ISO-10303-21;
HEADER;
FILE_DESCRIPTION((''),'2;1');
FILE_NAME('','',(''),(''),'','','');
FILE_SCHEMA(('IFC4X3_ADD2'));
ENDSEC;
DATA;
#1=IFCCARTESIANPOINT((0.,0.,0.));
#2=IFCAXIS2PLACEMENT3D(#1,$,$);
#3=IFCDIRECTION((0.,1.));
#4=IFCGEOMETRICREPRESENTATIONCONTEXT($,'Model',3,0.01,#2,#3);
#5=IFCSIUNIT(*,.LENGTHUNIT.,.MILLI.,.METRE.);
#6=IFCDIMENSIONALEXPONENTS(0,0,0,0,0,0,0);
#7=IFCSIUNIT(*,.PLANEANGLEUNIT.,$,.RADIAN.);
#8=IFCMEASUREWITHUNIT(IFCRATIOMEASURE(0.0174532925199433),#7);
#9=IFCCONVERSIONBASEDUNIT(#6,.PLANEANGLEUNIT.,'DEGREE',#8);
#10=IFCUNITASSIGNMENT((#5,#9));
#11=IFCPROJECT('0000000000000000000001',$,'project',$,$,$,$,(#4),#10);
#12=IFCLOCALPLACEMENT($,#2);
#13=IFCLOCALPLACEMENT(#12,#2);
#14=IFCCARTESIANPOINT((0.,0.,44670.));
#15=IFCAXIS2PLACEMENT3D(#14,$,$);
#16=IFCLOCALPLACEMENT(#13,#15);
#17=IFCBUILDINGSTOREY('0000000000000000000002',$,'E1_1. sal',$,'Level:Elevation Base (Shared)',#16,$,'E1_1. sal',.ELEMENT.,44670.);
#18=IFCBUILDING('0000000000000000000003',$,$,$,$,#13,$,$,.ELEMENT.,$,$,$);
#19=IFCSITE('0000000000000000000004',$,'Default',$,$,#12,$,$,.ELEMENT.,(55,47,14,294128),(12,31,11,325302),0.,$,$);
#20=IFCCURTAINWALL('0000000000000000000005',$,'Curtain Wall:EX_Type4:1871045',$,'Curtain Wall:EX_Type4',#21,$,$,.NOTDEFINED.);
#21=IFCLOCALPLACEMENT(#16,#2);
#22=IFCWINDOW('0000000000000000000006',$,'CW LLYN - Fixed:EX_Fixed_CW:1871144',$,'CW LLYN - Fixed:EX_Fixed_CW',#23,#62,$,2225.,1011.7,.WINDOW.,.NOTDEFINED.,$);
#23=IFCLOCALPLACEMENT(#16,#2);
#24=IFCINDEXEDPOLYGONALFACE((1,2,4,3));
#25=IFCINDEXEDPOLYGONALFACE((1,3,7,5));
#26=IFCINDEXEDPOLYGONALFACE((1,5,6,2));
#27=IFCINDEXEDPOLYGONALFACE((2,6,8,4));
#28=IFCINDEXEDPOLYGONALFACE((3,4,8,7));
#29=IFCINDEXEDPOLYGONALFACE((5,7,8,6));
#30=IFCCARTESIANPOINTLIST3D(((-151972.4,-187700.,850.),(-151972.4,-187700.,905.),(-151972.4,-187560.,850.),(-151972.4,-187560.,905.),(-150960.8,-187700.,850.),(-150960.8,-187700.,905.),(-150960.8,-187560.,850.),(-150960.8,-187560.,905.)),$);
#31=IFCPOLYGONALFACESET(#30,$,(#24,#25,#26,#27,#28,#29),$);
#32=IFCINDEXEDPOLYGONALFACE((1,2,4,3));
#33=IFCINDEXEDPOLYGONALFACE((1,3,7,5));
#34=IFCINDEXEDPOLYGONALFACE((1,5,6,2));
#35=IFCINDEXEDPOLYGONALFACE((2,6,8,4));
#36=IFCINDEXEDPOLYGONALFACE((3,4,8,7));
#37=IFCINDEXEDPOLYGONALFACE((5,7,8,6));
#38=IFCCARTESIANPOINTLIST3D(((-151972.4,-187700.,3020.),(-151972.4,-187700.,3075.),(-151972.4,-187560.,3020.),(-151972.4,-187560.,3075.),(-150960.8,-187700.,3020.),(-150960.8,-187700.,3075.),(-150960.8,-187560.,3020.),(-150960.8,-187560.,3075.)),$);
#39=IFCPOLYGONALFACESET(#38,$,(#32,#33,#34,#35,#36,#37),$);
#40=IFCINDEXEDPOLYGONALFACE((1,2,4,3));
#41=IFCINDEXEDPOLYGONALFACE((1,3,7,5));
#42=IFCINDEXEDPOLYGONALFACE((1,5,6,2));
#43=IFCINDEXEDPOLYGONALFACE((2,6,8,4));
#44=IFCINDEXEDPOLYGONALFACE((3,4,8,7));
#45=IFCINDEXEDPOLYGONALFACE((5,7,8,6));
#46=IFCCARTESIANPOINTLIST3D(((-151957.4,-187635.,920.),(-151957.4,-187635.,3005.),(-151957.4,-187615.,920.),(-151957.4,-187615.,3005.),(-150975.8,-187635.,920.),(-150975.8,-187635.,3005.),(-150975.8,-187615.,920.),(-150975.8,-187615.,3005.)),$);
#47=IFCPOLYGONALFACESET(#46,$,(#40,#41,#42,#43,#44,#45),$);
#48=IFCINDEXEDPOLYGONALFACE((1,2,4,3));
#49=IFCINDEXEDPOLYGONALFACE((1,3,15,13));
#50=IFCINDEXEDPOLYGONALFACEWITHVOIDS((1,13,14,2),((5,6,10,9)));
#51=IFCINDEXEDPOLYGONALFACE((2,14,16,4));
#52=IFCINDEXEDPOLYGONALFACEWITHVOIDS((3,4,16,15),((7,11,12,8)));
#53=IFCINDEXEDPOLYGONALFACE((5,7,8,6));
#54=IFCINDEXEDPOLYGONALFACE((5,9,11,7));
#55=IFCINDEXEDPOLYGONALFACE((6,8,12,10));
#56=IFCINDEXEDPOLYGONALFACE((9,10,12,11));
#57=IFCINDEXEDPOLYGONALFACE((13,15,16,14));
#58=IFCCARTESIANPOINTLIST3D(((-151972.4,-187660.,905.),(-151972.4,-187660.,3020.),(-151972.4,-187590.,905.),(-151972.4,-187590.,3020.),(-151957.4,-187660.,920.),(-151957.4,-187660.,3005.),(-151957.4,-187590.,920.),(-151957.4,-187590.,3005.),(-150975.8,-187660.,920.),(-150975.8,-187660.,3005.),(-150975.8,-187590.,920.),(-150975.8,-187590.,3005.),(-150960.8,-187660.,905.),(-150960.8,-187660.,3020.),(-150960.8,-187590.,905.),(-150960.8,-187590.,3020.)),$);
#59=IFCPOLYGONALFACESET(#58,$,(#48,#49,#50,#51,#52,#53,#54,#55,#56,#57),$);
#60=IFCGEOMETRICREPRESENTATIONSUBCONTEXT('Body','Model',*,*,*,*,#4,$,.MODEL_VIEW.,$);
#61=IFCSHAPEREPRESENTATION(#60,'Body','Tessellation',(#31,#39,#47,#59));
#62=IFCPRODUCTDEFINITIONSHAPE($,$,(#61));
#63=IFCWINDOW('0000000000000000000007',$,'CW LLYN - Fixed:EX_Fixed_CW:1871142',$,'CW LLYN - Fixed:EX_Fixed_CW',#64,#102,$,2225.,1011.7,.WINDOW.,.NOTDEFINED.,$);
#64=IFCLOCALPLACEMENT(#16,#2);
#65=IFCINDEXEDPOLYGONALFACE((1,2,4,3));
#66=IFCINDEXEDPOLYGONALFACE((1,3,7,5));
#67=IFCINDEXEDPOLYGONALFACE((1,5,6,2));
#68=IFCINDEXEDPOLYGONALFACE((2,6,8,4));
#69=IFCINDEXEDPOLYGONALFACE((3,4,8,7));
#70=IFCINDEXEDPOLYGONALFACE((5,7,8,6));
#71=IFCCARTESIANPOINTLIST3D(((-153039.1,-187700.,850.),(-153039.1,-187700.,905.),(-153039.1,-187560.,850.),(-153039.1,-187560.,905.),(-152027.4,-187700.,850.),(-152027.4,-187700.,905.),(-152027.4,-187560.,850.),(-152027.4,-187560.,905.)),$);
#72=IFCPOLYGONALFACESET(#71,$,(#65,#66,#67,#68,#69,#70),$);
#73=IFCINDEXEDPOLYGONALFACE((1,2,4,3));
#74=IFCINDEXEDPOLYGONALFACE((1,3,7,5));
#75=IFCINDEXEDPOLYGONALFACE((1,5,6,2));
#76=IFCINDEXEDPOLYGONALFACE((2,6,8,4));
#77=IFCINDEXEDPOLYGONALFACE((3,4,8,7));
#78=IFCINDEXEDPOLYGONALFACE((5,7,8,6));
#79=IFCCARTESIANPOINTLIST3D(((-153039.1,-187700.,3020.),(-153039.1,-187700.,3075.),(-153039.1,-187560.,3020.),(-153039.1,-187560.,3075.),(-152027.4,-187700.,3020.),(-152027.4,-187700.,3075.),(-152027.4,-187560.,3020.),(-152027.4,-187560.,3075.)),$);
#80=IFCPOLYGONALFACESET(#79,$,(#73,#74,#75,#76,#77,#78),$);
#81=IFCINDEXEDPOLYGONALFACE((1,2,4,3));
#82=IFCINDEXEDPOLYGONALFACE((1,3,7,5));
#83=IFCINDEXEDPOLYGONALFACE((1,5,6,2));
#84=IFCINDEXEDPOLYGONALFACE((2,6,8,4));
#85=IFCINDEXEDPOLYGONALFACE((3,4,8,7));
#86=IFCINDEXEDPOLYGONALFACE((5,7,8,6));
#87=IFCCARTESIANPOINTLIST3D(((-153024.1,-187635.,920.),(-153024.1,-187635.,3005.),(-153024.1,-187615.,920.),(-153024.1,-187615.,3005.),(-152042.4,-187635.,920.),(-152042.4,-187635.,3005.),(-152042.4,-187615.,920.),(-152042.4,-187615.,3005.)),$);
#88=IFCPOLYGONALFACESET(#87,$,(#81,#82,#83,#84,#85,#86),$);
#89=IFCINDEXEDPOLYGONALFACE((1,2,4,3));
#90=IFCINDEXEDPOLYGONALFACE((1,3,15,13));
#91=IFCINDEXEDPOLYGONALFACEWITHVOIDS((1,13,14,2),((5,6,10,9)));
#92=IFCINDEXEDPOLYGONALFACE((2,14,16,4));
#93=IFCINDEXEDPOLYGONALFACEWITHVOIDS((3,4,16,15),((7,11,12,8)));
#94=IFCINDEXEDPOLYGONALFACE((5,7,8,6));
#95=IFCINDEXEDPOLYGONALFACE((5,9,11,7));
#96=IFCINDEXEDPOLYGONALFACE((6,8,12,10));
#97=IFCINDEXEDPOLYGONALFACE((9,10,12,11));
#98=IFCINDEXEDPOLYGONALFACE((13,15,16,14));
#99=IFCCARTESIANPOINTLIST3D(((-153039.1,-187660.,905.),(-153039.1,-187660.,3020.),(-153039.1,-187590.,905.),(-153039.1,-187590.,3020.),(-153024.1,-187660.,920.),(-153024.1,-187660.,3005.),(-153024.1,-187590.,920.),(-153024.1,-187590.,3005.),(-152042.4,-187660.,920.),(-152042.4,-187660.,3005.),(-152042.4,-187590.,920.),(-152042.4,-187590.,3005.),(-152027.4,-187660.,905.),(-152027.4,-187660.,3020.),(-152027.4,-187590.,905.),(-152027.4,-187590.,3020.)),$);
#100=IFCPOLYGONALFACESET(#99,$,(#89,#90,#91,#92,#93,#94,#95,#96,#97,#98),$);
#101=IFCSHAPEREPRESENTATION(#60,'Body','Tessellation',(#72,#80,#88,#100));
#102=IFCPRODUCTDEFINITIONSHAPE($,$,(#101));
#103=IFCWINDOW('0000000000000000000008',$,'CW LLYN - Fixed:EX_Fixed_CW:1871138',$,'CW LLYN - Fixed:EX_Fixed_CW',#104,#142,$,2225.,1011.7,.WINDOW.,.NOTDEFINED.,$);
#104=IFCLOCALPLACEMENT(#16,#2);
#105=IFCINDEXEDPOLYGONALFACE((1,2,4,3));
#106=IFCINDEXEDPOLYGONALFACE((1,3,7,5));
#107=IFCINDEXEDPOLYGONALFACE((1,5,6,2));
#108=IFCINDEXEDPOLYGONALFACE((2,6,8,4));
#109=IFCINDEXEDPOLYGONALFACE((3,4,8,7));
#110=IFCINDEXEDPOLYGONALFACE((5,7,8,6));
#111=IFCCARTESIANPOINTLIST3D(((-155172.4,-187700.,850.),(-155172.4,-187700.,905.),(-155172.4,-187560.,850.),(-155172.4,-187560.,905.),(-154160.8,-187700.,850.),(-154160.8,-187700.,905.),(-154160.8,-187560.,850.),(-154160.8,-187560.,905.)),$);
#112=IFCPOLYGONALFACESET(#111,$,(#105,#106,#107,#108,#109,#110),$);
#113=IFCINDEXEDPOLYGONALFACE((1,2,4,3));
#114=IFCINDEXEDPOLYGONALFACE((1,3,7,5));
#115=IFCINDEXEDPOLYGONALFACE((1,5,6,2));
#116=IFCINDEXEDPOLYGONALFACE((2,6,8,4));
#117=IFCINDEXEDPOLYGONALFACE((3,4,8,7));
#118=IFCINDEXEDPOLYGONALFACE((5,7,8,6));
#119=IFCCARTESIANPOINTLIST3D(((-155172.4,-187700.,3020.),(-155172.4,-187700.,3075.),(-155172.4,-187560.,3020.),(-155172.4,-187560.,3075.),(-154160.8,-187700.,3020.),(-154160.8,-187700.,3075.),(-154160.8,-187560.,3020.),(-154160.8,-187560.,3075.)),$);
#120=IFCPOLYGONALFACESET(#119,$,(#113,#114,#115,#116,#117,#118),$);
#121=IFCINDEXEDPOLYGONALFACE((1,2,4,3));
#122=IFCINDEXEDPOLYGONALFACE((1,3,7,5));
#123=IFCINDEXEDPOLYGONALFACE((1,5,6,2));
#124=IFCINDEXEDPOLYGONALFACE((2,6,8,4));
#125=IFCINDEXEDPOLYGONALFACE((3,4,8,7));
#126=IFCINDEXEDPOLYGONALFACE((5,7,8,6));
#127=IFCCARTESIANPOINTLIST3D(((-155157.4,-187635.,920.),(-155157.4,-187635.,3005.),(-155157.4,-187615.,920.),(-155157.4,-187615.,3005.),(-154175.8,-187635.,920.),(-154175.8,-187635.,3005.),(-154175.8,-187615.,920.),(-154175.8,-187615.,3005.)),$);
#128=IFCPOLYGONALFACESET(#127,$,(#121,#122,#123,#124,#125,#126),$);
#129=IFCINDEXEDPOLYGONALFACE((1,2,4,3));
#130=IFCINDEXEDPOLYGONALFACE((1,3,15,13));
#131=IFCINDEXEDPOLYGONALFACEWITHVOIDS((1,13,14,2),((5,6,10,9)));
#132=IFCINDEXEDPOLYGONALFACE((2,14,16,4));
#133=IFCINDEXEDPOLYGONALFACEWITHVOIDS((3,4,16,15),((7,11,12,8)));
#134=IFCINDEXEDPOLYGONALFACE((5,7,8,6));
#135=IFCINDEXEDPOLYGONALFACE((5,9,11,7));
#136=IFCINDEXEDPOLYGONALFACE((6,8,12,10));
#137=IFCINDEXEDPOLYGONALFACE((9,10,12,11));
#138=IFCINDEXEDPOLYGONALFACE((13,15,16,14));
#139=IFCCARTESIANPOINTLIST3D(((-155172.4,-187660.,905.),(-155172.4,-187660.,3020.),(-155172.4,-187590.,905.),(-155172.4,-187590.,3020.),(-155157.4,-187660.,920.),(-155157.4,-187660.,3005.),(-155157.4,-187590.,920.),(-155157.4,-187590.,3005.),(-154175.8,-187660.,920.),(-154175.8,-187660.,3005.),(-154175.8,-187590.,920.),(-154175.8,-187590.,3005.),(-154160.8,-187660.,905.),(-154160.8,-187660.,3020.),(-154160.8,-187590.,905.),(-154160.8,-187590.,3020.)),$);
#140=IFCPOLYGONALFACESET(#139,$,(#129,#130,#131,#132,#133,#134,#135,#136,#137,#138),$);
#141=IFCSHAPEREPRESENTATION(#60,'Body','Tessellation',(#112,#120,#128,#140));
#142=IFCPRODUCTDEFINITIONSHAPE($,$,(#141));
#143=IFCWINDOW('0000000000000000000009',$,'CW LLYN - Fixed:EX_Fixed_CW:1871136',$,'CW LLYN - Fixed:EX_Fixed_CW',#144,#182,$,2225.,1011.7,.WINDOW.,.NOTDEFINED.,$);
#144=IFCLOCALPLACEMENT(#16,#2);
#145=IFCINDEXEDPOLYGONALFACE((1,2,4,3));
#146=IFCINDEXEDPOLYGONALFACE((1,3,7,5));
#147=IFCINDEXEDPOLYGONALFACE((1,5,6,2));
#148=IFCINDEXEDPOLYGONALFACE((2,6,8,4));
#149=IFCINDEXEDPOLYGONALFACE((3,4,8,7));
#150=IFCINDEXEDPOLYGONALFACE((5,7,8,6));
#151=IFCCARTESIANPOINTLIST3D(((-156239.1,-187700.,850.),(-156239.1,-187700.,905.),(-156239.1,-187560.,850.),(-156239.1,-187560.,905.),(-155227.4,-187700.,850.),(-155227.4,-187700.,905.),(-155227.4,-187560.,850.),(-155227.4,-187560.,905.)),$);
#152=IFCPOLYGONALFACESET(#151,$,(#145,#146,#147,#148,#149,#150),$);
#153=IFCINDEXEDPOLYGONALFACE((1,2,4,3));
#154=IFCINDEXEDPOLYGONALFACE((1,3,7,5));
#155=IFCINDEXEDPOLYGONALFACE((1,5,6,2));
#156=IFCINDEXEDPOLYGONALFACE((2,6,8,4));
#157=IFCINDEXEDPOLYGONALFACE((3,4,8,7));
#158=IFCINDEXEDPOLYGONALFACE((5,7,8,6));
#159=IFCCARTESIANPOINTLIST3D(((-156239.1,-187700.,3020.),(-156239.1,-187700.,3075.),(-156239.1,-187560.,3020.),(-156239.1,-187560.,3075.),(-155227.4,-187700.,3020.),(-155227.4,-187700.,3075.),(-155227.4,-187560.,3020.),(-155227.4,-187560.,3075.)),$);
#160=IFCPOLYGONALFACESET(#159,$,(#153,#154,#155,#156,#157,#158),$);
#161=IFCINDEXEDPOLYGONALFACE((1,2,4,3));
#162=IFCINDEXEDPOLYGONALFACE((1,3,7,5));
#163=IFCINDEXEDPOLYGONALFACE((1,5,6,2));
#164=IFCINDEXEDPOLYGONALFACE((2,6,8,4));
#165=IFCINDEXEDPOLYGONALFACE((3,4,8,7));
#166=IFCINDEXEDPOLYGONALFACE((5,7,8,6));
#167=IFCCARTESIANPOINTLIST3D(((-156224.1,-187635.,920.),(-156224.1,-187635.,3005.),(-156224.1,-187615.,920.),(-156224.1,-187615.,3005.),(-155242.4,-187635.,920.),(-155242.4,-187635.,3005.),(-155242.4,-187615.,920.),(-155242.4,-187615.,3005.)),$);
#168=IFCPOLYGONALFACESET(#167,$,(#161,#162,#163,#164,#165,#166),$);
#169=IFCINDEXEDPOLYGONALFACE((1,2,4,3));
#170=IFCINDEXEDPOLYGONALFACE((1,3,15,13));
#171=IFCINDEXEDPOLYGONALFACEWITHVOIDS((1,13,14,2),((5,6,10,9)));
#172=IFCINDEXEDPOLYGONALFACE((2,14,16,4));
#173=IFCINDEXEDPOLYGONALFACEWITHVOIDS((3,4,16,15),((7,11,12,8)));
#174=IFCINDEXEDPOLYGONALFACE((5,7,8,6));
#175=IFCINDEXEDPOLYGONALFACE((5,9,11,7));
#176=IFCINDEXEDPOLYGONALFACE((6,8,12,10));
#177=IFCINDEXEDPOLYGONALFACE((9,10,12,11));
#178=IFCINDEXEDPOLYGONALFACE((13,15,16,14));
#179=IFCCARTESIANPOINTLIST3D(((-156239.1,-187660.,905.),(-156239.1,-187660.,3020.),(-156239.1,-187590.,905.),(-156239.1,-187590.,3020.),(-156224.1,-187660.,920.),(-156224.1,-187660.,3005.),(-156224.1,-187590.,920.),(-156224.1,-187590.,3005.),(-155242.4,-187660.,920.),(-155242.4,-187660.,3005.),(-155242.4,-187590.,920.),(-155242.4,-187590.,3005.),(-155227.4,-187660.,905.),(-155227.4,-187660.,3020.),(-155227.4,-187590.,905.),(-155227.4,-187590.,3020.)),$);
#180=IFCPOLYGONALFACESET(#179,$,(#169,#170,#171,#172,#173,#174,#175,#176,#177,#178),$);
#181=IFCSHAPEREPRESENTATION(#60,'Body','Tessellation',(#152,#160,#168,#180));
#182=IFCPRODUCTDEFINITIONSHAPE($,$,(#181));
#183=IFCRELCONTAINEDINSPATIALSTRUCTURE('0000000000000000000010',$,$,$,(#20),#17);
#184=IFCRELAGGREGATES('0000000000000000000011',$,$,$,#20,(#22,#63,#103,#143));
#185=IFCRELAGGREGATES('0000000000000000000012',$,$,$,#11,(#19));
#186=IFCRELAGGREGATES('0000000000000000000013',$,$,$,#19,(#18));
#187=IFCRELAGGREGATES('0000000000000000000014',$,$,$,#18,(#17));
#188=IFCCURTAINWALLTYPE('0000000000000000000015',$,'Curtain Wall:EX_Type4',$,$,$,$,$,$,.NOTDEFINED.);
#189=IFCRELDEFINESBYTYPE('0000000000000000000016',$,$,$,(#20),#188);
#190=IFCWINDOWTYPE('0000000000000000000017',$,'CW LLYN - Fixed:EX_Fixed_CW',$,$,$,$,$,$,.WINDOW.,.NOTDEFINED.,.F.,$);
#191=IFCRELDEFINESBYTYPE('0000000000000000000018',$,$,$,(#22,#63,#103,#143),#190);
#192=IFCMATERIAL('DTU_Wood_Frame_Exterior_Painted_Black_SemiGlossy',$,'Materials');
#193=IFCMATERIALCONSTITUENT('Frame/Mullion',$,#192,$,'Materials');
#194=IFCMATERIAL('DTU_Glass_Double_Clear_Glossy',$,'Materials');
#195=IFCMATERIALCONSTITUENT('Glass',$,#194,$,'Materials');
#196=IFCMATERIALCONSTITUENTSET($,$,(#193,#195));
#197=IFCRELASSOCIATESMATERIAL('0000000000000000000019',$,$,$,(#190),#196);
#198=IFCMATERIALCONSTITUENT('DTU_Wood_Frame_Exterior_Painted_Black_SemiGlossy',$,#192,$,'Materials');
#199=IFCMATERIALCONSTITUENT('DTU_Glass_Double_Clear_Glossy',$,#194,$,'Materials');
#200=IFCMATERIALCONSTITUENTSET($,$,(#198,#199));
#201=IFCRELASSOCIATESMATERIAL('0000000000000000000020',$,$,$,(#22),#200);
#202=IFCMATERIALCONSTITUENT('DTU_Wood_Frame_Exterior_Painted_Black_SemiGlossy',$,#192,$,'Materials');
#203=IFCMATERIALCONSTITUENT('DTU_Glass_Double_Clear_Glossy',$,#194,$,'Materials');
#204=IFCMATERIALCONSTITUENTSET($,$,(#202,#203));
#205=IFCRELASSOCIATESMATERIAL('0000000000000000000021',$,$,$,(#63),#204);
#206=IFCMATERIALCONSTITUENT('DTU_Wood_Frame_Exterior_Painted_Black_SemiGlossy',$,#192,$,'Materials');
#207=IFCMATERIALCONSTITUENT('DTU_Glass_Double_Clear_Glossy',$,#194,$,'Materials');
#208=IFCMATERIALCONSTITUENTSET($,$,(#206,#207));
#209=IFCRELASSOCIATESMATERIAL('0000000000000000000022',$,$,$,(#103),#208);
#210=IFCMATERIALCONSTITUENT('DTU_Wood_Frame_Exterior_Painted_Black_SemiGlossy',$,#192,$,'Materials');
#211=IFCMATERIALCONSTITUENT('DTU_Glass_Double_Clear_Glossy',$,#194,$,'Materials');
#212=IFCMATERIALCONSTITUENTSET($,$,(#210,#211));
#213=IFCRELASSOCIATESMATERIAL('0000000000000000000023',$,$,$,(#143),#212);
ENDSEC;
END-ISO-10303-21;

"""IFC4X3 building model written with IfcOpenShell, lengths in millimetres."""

from ifc_helpers import new_model, entity, si_unit, converted_unit, direction, frame, frame_2d, origin, origin_2d_with_axis, place, context, subcontext, project, spatial, polyline, rectangle, outline, extrude, source, transform, mapped, material, constituent, constituent_set, type_object, type_shapes, element, aggregate, save


model = new_model("IFC4X3")

# Units and contexts
model_context = context("Model", 3, precision=0.01, world=origin(), true_north=direction((0.0, 1.0)))
body_context = subcontext(model_context, "Body", "Model", "MODEL_VIEW")
ifc_project = project(units=[si_unit("LENGTHUNIT", "METRE", prefix="MILLI"), converted_unit("PLANEANGLEUNIT", "DEGREE", entity("IfcRatioMeasure", 0.0174532925199433), si_unit("PLANEANGLEUNIT", "RADIAN"), dimensions=[0, 0, 0, 0, 0, 0, 0])], contexts=[model_context])

# Site, building, storey
site_placement = place(None, origin())
site = spatial("IfcSite", under=ifc_project, at=site_placement, Name="Default", CompositionType="ELEMENT", RefLatitude=(55, 47, 14, 294128), RefLongitude=(12, 31, 11, 325302), RefElevation=0.0)
building_placement = place(site_placement, origin())
building = spatial("IfcBuilding", under=site, at=building_placement, CompositionType="ELEMENT")
storey_placement = place(building_placement, frame((0.0, 0.0, 44670.0)))
storey = spatial("IfcBuildingStorey", under=building, at=storey_placement, Name="E1_1. sal", ObjectType="Level:Elevation Base (Shared)", LongName="E1_1. sal", CompositionType="ELEMENT", Elevation=44670.0)

# Curtain wall, windows
curtain_wall_type = type_object("IfcCurtainWallType", Name="Curtain Wall:EX_Type4", PredefinedType="NOTDEFINED")
curtain_wall_placement = place(storey_placement, frame((0.0, 0.0, -44670.0)))
curtain_wall = element("IfcCurtainWall", 1, at=curtain_wall_placement, inside=storey, type_object=curtain_wall_type, Name="Curtain Wall:EX_Type4:1871045", ObjectType="Curtain Wall:EX_Type4", PredefinedType="NOTDEFINED")
ifc_material_1 = material(Name="DTU_Wood_Frame_Exterior_Painted_Black_SemiGlossy", Category="Materials")
ifc_material_2 = material(Name="DTU_Glass_Double_Clear_Glossy", Category="Materials")
ifc_constituent_1 = constituent(ifc_material_1, Name="Frame/Mullion", Category="Materials")
ifc_constituent_2 = constituent(ifc_material_2, Name="Glass", Category="Materials")
ifc_constituent_set_1 = constituent_set(constituents=[ifc_constituent_1, ifc_constituent_2])
window_type_1 = type_object("IfcWindowType", Name="CW LLYN - Fixed:EX_Fixed_CW", ParameterTakesPrecedence=False, PartitioningType="NOTDEFINED", PredefinedType="WINDOW", material=ifc_constituent_set_1)
shared_shape_1 = source(origin(), body_context, "Body", "SweptSolid", [
    extrude(rectangle(XDim=140.0, YDim=1011.7, at=origin_2d_with_axis()), frame((0.0, -130.0, 0.0), z_axis=(0.0, 0.0, 1.0), x_axis=(0.0, -1.0, 0.0)), (0.0, 0.0, 1.0), 55.0),
    extrude(rectangle(XDim=140.0, YDim=1011.7, at=frame_2d((0.0, 0.0), x_axis=(1.0, 0.0))), frame((0.0, -130.0, 2170.0), z_axis=(0.0, 0.0, 1.0), x_axis=(0.0, -1.0, 0.0)), (0.0, 0.0, 1.0), 55.0),
    extrude(rectangle(XDim=981.7, YDim=20.0, at=frame_2d((0.0, 0.0), x_axis=(1.0, 0.0))), frame((0.0, -125.0, 70.0), z_axis=(0.0, 0.0, 1.0), x_axis=(-1.0, 0.0, 0.0)), (0.0, 0.0, 1.0), 2085.0),
    extrude(outline(polyline([(-1057.5, -505.8), (1057.5, -505.8), (1057.5, 505.8), (-1057.5, 505.8), (-1057.5, -505.8)]), holes=[polyline([(-1042.5, 490.8), (1042.5, 490.8), (1042.5, -490.8), (-1042.5, -490.8), (-1042.5, 490.8)])]), frame((0.0, -90.0, 1112.5), z_axis=(0.0, -1.0, 0.0), x_axis=(0.0, 0.0, 1.0)), (0.0, 0.0, 1.0), 70.0),
])
type_shapes(window_type_1, [shared_shape_1])
ifc_constituent_3 = constituent(ifc_material_1, Name="DTU_Wood_Frame_Exterior_Painted_Black_SemiGlossy", Category="Materials")
ifc_constituent_4 = constituent(ifc_material_2, Name="DTU_Glass_Double_Clear_Glossy", Category="Materials")
ifc_constituent_set_2 = constituent_set(constituents=[ifc_constituent_3, ifc_constituent_4])
window_1_placement = place(curtain_wall_placement, frame((-151466.6, -187500.0, 45520.0)))
window_1 = element("IfcWindow", 2, at=window_1_placement, type_object=window_type_1, material=ifc_constituent_set_2, Name="CW LLYN - Fixed:EX_Fixed_CW:1871144", ObjectType="CW LLYN - Fixed:EX_Fixed_CW", OverallHeight=2225.0, OverallWidth=1011.7, PartitioningType="NOTDEFINED", PredefinedType="WINDOW", context=body_context, shape_type="MappedRepresentation", body=[
    mapped(shared_shape_1, transform((0.0, 0.0, 0.0), scale=1.0)),
])
ifc_constituent_5 = constituent(ifc_material_1, Name="DTU_Wood_Frame_Exterior_Painted_Black_SemiGlossy", Category="Materials")
ifc_constituent_6 = constituent(ifc_material_2, Name="DTU_Glass_Double_Clear_Glossy", Category="Materials")
ifc_constituent_set_3 = constituent_set(constituents=[ifc_constituent_5, ifc_constituent_6])
window_2_placement = place(curtain_wall_placement, frame((-152533.3, -187500.0, 45520.0)))
window_2 = element("IfcWindow", 3, at=window_2_placement, type_object=window_type_1, material=ifc_constituent_set_3, Name="CW LLYN - Fixed:EX_Fixed_CW:1871142", ObjectType="CW LLYN - Fixed:EX_Fixed_CW", OverallHeight=2225.0, OverallWidth=1011.7, PartitioningType="NOTDEFINED", PredefinedType="WINDOW", context=body_context, shape_type="MappedRepresentation", body=[
    mapped(shared_shape_1, transform((0.0, 0.0, 0.0), scale=1.0)),
])
ifc_constituent_7 = constituent(ifc_material_1, Name="DTU_Wood_Frame_Exterior_Painted_Black_SemiGlossy", Category="Materials")
ifc_constituent_8 = constituent(ifc_material_2, Name="DTU_Glass_Double_Clear_Glossy", Category="Materials")
ifc_constituent_set_4 = constituent_set(constituents=[ifc_constituent_7, ifc_constituent_8])
window_3_placement = place(curtain_wall_placement, frame((-154666.6, -187500.0, 45520.0)))
window_3 = element("IfcWindow", 4, at=window_3_placement, type_object=window_type_1, material=ifc_constituent_set_4, Name="CW LLYN - Fixed:EX_Fixed_CW:1871138", ObjectType="CW LLYN - Fixed:EX_Fixed_CW", OverallHeight=2225.0, OverallWidth=1011.7, PartitioningType="NOTDEFINED", PredefinedType="WINDOW", context=body_context, shape_type="MappedRepresentation", body=[
    mapped(shared_shape_1, transform((0.0, 0.0, 0.0), scale=1.0)),
])
ifc_constituent_9 = constituent(ifc_material_1, Name="DTU_Wood_Frame_Exterior_Painted_Black_SemiGlossy", Category="Materials")
ifc_constituent_10 = constituent(ifc_material_2, Name="DTU_Glass_Double_Clear_Glossy", Category="Materials")
ifc_constituent_set_5 = constituent_set(constituents=[ifc_constituent_9, ifc_constituent_10])
window_4_placement = place(curtain_wall_placement, frame((-155733.3, -187500.0, 45520.0)))
window_4 = element("IfcWindow", 5, at=window_4_placement, type_object=window_type_1, material=ifc_constituent_set_5, Name="CW LLYN - Fixed:EX_Fixed_CW:1871136", ObjectType="CW LLYN - Fixed:EX_Fixed_CW", OverallHeight=2225.0, OverallWidth=1011.7, PartitioningType="NOTDEFINED", PredefinedType="WINDOW", context=body_context, shape_type="MappedRepresentation", body=[
    mapped(shared_shape_1, transform((0.0, 0.0, 0.0), scale=1.0)),
])
aggregate(curtain_wall, [window_1, window_2, window_3, window_4])

save(model, "model.ifc")
